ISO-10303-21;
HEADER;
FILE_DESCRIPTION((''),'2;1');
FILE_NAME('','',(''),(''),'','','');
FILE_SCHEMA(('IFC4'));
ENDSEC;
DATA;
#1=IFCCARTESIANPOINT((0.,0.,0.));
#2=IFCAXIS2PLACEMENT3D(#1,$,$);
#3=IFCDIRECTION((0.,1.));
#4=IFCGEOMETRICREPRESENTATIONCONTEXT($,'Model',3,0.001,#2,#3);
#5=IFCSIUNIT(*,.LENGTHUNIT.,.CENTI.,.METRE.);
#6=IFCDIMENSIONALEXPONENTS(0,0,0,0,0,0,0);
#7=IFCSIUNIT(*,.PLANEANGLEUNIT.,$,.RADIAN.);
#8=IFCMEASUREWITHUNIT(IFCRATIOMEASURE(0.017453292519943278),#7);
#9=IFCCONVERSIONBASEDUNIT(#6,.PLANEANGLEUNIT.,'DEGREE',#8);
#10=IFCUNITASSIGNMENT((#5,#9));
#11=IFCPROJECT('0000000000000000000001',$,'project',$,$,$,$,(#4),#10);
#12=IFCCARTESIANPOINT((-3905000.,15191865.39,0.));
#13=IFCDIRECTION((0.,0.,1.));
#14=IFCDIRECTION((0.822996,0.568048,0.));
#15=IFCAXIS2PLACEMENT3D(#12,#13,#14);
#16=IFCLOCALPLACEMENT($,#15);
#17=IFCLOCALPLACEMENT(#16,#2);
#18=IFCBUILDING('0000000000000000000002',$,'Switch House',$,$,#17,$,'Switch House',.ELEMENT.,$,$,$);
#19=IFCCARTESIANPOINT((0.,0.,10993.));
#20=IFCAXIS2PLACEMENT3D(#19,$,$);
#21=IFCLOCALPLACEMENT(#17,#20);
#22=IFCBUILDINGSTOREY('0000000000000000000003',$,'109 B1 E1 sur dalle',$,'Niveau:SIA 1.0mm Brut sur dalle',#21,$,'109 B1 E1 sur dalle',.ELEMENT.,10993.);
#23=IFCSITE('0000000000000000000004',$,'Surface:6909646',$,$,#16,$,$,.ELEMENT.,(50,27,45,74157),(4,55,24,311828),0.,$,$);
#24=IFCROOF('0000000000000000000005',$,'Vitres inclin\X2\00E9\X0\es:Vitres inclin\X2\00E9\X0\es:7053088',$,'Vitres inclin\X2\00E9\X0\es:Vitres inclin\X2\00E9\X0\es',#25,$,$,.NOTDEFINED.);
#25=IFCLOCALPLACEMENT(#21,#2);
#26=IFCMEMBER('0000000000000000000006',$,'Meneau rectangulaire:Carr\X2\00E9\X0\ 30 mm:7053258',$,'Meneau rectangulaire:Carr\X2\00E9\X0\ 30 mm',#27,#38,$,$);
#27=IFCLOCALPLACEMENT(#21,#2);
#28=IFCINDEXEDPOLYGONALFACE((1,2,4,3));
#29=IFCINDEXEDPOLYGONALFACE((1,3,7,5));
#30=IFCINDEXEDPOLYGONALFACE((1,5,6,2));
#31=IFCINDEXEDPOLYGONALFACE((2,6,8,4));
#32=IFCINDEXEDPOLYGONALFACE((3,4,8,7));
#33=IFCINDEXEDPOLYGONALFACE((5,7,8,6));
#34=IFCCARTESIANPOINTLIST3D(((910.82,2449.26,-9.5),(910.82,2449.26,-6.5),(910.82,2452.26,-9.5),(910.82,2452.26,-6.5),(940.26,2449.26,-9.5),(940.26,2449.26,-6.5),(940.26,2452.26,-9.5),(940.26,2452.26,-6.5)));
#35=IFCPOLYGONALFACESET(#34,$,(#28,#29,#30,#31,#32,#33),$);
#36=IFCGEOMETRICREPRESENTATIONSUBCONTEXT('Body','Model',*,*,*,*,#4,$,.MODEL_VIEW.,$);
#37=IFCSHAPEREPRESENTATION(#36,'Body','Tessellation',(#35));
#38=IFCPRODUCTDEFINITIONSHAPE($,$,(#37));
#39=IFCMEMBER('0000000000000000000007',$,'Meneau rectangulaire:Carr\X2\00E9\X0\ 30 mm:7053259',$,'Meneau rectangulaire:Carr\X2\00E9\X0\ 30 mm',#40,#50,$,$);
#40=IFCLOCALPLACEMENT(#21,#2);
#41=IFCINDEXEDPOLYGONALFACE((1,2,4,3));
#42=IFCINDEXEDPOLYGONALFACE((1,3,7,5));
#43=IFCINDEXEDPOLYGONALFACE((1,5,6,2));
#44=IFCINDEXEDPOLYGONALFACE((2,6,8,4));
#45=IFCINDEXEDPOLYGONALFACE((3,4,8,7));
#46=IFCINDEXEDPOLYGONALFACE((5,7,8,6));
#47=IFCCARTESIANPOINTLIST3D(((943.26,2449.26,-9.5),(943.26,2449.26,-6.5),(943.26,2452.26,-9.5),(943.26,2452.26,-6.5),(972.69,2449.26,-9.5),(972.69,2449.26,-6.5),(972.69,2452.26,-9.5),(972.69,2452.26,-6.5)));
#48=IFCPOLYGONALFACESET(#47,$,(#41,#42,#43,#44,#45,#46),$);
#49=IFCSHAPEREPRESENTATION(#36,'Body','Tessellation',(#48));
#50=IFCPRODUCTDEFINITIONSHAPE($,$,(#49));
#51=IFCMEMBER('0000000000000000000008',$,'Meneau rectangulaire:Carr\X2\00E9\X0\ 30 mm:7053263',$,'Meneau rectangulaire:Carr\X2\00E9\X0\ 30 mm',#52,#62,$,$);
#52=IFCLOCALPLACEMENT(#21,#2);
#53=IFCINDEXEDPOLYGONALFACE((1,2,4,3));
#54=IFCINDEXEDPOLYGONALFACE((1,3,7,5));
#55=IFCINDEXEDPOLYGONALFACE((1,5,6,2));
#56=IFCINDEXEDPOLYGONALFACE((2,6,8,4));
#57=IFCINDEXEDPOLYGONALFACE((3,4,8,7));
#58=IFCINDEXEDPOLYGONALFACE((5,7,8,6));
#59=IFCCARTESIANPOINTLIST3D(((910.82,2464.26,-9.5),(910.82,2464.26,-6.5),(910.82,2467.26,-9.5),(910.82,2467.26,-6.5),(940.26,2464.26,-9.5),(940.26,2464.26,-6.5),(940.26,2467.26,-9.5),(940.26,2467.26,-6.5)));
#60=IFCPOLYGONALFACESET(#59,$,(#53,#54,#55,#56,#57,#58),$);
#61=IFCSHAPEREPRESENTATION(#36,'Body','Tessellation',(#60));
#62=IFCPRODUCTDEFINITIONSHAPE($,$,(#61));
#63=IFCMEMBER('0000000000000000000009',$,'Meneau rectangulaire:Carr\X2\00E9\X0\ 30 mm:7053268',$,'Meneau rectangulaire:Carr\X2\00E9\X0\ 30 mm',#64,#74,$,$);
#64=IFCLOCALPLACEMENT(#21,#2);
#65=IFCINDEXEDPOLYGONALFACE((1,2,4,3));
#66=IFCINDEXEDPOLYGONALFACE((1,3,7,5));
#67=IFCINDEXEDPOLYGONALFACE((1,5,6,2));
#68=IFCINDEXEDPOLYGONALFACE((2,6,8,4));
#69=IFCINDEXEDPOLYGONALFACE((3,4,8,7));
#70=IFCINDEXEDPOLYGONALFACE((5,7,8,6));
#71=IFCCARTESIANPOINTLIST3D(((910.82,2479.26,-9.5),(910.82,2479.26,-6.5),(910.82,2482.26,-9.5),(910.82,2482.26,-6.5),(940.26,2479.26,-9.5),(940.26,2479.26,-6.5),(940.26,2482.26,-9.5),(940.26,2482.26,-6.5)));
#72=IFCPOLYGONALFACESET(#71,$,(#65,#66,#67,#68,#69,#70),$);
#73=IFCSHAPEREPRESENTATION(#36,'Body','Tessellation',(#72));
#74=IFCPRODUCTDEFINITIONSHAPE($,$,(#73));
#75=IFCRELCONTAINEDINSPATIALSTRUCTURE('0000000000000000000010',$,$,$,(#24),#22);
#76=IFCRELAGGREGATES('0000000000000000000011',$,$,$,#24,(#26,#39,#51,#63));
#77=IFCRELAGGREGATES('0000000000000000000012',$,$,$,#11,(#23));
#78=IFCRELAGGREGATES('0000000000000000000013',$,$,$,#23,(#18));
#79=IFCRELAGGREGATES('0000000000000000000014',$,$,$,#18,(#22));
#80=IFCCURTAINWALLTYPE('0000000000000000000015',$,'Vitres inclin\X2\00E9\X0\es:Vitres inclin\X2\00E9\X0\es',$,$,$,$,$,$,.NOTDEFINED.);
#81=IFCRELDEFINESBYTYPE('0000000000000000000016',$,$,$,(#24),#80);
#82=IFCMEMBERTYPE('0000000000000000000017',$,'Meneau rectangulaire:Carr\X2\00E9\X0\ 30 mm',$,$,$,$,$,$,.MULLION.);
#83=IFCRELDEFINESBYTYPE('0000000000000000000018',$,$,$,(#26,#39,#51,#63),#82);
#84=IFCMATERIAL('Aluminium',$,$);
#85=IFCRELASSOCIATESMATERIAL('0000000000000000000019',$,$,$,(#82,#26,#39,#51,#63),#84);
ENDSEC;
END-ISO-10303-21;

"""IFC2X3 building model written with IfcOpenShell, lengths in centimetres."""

from ifc_helpers import new_model, entity, si_unit, converted_unit, direction, frame, origin, origin_2d_with_axis, place, context, subcontext, project, spatial, rectangle, extrude, source, transform, mapped, material, type_object, type_shapes, element, aggregate, save


model = new_model("IFC2X3")

# Units and contexts
model_context = context("Model", 3, precision=0.001, world=origin(), true_north=direction((0.0, 1.0)))
body_context = subcontext(model_context, "Body", "Model", "MODEL_VIEW")
ifc_project = project(units=[si_unit("LENGTHUNIT", "METRE", prefix="CENTI"), converted_unit("PLANEANGLEUNIT", "DEGREE", entity("IfcRatioMeasure", 0.017453292519943278), si_unit("PLANEANGLEUNIT", "RADIAN"), dimensions=[0, 0, 0, 0, 0, 0, 0])], contexts=[model_context])

# Site, building, storey
site_placement = place(None, frame((-3905000.0, 15191865.39, 0.0), z_axis=(0.0, 0.0, 1.0), x_axis=(0.822996, 0.568048, 0.0)))
site = spatial("IfcSite", under=ifc_project, at=site_placement, Name="Surface:6909646", CompositionType="ELEMENT", RefLatitude=(50, 27, 45, 74157), RefLongitude=(4, 55, 24, 311828), RefElevation=0.0)
building_placement = place(site_placement, origin())
building = spatial("IfcBuilding", under=site, at=building_placement, Name="Switch House", LongName="Switch House", CompositionType="ELEMENT")
storey_placement = place(building_placement, frame((0.0, 0.0, 10993.0)))
storey = spatial("IfcBuildingStorey", under=building, at=storey_placement, Name="109 B1 E1 sur dalle", ObjectType="Niveau:SIA 1.0mm Brut sur dalle", LongName="109 B1 E1 sur dalle", CompositionType="ELEMENT", Elevation=10993.0)

# Roof, members
curtain_wall_type = type_object("IfcCurtainWallType", Name="Vitres inclinées:Vitres inclinées", PredefinedType="NOTDEFINED")
roof_placement = place(storey_placement, frame((0.0, 0.0, -10993.0)))
roof = element("IfcRoof", 1, at=roof_placement, inside=storey, type_object=curtain_wall_type, Name="Vitres inclinées:Vitres inclinées:7053088", ObjectType="Vitres inclinées:Vitres inclinées", ShapeType="NOTDEFINED")
ifc_material = material(Name="Aluminium")
member_type_1 = type_object("IfcMemberType", Name="Meneau rectangulaire:Carré 30 mm", PredefinedType="MULLION", material=ifc_material)
shared_shape_1 = source(origin(), body_context, "Body", "SweptSolid", [
    extrude(rectangle(XDim=3.0, YDim=3.0, at=origin_2d_with_axis()), frame((0.0, 0.0, -29.44), z_axis=(0.0, 0.0, 1.0), x_axis=(0.0, -1.0, 0.0)), (0.0, 0.0, 1.0), 29.44),
])
type_shapes(member_type_1, [shared_shape_1])
member_1_placement = place(roof_placement, frame((910.82, 2450.76, 10985.0), z_axis=(-1.0, 0.0, 0.0), x_axis=(0.0, 1.0, 0.0)))
member_1 = element("IfcMember", 2, at=member_1_placement, type_object=member_type_1, material=ifc_material, Name="Meneau rectangulaire:Carré 30 mm:7053258", ObjectType="Meneau rectangulaire:Carré 30 mm", context=body_context, shape_type="MappedRepresentation", body=[
    mapped(shared_shape_1, transform((0.0, 0.0, 0.0), scale=1.0)),
])
member_2_placement = place(roof_placement, frame((943.26, 2450.76, 10985.0), z_axis=(-1.0, 0.0, 0.0), x_axis=(0.0, 1.0, 0.0)))
member_2 = element("IfcMember", 3, at=member_2_placement, type_object=member_type_1, material=ifc_material, Name="Meneau rectangulaire:Carré 30 mm:7053259", ObjectType="Meneau rectangulaire:Carré 30 mm", context=body_context, shape_type="MappedRepresentation", body=[
    mapped(shared_shape_1, transform((0.0, 0.0, 0.0), scale=1.0)),
])
member_3_placement = place(roof_placement, frame((910.82, 2465.76, 10985.0), z_axis=(-1.0, 0.0, 0.0), x_axis=(0.0, 1.0, 0.0)))
member_3 = element("IfcMember", 4, at=member_3_placement, type_object=member_type_1, material=ifc_material, Name="Meneau rectangulaire:Carré 30 mm:7053263", ObjectType="Meneau rectangulaire:Carré 30 mm", context=body_context, shape_type="MappedRepresentation", body=[
    mapped(shared_shape_1, transform((0.0, 0.0, 0.0), scale=1.0)),
])
member_4_placement = place(roof_placement, frame((910.82, 2480.76, 10985.0), z_axis=(-1.0, 0.0, 0.0), x_axis=(0.0, 1.0, 0.0)))
member_4 = element("IfcMember", 5, at=member_4_placement, type_object=member_type_1, material=ifc_material, Name="Meneau rectangulaire:Carré 30 mm:7053268", ObjectType="Meneau rectangulaire:Carré 30 mm", context=body_context, shape_type="MappedRepresentation", body=[
    mapped(shared_shape_1, transform((0.0, 0.0, 0.0), scale=1.0)),
])
aggregate(roof, [member_1, member_2, member_3, member_4])

save(model, "model.ifc")
